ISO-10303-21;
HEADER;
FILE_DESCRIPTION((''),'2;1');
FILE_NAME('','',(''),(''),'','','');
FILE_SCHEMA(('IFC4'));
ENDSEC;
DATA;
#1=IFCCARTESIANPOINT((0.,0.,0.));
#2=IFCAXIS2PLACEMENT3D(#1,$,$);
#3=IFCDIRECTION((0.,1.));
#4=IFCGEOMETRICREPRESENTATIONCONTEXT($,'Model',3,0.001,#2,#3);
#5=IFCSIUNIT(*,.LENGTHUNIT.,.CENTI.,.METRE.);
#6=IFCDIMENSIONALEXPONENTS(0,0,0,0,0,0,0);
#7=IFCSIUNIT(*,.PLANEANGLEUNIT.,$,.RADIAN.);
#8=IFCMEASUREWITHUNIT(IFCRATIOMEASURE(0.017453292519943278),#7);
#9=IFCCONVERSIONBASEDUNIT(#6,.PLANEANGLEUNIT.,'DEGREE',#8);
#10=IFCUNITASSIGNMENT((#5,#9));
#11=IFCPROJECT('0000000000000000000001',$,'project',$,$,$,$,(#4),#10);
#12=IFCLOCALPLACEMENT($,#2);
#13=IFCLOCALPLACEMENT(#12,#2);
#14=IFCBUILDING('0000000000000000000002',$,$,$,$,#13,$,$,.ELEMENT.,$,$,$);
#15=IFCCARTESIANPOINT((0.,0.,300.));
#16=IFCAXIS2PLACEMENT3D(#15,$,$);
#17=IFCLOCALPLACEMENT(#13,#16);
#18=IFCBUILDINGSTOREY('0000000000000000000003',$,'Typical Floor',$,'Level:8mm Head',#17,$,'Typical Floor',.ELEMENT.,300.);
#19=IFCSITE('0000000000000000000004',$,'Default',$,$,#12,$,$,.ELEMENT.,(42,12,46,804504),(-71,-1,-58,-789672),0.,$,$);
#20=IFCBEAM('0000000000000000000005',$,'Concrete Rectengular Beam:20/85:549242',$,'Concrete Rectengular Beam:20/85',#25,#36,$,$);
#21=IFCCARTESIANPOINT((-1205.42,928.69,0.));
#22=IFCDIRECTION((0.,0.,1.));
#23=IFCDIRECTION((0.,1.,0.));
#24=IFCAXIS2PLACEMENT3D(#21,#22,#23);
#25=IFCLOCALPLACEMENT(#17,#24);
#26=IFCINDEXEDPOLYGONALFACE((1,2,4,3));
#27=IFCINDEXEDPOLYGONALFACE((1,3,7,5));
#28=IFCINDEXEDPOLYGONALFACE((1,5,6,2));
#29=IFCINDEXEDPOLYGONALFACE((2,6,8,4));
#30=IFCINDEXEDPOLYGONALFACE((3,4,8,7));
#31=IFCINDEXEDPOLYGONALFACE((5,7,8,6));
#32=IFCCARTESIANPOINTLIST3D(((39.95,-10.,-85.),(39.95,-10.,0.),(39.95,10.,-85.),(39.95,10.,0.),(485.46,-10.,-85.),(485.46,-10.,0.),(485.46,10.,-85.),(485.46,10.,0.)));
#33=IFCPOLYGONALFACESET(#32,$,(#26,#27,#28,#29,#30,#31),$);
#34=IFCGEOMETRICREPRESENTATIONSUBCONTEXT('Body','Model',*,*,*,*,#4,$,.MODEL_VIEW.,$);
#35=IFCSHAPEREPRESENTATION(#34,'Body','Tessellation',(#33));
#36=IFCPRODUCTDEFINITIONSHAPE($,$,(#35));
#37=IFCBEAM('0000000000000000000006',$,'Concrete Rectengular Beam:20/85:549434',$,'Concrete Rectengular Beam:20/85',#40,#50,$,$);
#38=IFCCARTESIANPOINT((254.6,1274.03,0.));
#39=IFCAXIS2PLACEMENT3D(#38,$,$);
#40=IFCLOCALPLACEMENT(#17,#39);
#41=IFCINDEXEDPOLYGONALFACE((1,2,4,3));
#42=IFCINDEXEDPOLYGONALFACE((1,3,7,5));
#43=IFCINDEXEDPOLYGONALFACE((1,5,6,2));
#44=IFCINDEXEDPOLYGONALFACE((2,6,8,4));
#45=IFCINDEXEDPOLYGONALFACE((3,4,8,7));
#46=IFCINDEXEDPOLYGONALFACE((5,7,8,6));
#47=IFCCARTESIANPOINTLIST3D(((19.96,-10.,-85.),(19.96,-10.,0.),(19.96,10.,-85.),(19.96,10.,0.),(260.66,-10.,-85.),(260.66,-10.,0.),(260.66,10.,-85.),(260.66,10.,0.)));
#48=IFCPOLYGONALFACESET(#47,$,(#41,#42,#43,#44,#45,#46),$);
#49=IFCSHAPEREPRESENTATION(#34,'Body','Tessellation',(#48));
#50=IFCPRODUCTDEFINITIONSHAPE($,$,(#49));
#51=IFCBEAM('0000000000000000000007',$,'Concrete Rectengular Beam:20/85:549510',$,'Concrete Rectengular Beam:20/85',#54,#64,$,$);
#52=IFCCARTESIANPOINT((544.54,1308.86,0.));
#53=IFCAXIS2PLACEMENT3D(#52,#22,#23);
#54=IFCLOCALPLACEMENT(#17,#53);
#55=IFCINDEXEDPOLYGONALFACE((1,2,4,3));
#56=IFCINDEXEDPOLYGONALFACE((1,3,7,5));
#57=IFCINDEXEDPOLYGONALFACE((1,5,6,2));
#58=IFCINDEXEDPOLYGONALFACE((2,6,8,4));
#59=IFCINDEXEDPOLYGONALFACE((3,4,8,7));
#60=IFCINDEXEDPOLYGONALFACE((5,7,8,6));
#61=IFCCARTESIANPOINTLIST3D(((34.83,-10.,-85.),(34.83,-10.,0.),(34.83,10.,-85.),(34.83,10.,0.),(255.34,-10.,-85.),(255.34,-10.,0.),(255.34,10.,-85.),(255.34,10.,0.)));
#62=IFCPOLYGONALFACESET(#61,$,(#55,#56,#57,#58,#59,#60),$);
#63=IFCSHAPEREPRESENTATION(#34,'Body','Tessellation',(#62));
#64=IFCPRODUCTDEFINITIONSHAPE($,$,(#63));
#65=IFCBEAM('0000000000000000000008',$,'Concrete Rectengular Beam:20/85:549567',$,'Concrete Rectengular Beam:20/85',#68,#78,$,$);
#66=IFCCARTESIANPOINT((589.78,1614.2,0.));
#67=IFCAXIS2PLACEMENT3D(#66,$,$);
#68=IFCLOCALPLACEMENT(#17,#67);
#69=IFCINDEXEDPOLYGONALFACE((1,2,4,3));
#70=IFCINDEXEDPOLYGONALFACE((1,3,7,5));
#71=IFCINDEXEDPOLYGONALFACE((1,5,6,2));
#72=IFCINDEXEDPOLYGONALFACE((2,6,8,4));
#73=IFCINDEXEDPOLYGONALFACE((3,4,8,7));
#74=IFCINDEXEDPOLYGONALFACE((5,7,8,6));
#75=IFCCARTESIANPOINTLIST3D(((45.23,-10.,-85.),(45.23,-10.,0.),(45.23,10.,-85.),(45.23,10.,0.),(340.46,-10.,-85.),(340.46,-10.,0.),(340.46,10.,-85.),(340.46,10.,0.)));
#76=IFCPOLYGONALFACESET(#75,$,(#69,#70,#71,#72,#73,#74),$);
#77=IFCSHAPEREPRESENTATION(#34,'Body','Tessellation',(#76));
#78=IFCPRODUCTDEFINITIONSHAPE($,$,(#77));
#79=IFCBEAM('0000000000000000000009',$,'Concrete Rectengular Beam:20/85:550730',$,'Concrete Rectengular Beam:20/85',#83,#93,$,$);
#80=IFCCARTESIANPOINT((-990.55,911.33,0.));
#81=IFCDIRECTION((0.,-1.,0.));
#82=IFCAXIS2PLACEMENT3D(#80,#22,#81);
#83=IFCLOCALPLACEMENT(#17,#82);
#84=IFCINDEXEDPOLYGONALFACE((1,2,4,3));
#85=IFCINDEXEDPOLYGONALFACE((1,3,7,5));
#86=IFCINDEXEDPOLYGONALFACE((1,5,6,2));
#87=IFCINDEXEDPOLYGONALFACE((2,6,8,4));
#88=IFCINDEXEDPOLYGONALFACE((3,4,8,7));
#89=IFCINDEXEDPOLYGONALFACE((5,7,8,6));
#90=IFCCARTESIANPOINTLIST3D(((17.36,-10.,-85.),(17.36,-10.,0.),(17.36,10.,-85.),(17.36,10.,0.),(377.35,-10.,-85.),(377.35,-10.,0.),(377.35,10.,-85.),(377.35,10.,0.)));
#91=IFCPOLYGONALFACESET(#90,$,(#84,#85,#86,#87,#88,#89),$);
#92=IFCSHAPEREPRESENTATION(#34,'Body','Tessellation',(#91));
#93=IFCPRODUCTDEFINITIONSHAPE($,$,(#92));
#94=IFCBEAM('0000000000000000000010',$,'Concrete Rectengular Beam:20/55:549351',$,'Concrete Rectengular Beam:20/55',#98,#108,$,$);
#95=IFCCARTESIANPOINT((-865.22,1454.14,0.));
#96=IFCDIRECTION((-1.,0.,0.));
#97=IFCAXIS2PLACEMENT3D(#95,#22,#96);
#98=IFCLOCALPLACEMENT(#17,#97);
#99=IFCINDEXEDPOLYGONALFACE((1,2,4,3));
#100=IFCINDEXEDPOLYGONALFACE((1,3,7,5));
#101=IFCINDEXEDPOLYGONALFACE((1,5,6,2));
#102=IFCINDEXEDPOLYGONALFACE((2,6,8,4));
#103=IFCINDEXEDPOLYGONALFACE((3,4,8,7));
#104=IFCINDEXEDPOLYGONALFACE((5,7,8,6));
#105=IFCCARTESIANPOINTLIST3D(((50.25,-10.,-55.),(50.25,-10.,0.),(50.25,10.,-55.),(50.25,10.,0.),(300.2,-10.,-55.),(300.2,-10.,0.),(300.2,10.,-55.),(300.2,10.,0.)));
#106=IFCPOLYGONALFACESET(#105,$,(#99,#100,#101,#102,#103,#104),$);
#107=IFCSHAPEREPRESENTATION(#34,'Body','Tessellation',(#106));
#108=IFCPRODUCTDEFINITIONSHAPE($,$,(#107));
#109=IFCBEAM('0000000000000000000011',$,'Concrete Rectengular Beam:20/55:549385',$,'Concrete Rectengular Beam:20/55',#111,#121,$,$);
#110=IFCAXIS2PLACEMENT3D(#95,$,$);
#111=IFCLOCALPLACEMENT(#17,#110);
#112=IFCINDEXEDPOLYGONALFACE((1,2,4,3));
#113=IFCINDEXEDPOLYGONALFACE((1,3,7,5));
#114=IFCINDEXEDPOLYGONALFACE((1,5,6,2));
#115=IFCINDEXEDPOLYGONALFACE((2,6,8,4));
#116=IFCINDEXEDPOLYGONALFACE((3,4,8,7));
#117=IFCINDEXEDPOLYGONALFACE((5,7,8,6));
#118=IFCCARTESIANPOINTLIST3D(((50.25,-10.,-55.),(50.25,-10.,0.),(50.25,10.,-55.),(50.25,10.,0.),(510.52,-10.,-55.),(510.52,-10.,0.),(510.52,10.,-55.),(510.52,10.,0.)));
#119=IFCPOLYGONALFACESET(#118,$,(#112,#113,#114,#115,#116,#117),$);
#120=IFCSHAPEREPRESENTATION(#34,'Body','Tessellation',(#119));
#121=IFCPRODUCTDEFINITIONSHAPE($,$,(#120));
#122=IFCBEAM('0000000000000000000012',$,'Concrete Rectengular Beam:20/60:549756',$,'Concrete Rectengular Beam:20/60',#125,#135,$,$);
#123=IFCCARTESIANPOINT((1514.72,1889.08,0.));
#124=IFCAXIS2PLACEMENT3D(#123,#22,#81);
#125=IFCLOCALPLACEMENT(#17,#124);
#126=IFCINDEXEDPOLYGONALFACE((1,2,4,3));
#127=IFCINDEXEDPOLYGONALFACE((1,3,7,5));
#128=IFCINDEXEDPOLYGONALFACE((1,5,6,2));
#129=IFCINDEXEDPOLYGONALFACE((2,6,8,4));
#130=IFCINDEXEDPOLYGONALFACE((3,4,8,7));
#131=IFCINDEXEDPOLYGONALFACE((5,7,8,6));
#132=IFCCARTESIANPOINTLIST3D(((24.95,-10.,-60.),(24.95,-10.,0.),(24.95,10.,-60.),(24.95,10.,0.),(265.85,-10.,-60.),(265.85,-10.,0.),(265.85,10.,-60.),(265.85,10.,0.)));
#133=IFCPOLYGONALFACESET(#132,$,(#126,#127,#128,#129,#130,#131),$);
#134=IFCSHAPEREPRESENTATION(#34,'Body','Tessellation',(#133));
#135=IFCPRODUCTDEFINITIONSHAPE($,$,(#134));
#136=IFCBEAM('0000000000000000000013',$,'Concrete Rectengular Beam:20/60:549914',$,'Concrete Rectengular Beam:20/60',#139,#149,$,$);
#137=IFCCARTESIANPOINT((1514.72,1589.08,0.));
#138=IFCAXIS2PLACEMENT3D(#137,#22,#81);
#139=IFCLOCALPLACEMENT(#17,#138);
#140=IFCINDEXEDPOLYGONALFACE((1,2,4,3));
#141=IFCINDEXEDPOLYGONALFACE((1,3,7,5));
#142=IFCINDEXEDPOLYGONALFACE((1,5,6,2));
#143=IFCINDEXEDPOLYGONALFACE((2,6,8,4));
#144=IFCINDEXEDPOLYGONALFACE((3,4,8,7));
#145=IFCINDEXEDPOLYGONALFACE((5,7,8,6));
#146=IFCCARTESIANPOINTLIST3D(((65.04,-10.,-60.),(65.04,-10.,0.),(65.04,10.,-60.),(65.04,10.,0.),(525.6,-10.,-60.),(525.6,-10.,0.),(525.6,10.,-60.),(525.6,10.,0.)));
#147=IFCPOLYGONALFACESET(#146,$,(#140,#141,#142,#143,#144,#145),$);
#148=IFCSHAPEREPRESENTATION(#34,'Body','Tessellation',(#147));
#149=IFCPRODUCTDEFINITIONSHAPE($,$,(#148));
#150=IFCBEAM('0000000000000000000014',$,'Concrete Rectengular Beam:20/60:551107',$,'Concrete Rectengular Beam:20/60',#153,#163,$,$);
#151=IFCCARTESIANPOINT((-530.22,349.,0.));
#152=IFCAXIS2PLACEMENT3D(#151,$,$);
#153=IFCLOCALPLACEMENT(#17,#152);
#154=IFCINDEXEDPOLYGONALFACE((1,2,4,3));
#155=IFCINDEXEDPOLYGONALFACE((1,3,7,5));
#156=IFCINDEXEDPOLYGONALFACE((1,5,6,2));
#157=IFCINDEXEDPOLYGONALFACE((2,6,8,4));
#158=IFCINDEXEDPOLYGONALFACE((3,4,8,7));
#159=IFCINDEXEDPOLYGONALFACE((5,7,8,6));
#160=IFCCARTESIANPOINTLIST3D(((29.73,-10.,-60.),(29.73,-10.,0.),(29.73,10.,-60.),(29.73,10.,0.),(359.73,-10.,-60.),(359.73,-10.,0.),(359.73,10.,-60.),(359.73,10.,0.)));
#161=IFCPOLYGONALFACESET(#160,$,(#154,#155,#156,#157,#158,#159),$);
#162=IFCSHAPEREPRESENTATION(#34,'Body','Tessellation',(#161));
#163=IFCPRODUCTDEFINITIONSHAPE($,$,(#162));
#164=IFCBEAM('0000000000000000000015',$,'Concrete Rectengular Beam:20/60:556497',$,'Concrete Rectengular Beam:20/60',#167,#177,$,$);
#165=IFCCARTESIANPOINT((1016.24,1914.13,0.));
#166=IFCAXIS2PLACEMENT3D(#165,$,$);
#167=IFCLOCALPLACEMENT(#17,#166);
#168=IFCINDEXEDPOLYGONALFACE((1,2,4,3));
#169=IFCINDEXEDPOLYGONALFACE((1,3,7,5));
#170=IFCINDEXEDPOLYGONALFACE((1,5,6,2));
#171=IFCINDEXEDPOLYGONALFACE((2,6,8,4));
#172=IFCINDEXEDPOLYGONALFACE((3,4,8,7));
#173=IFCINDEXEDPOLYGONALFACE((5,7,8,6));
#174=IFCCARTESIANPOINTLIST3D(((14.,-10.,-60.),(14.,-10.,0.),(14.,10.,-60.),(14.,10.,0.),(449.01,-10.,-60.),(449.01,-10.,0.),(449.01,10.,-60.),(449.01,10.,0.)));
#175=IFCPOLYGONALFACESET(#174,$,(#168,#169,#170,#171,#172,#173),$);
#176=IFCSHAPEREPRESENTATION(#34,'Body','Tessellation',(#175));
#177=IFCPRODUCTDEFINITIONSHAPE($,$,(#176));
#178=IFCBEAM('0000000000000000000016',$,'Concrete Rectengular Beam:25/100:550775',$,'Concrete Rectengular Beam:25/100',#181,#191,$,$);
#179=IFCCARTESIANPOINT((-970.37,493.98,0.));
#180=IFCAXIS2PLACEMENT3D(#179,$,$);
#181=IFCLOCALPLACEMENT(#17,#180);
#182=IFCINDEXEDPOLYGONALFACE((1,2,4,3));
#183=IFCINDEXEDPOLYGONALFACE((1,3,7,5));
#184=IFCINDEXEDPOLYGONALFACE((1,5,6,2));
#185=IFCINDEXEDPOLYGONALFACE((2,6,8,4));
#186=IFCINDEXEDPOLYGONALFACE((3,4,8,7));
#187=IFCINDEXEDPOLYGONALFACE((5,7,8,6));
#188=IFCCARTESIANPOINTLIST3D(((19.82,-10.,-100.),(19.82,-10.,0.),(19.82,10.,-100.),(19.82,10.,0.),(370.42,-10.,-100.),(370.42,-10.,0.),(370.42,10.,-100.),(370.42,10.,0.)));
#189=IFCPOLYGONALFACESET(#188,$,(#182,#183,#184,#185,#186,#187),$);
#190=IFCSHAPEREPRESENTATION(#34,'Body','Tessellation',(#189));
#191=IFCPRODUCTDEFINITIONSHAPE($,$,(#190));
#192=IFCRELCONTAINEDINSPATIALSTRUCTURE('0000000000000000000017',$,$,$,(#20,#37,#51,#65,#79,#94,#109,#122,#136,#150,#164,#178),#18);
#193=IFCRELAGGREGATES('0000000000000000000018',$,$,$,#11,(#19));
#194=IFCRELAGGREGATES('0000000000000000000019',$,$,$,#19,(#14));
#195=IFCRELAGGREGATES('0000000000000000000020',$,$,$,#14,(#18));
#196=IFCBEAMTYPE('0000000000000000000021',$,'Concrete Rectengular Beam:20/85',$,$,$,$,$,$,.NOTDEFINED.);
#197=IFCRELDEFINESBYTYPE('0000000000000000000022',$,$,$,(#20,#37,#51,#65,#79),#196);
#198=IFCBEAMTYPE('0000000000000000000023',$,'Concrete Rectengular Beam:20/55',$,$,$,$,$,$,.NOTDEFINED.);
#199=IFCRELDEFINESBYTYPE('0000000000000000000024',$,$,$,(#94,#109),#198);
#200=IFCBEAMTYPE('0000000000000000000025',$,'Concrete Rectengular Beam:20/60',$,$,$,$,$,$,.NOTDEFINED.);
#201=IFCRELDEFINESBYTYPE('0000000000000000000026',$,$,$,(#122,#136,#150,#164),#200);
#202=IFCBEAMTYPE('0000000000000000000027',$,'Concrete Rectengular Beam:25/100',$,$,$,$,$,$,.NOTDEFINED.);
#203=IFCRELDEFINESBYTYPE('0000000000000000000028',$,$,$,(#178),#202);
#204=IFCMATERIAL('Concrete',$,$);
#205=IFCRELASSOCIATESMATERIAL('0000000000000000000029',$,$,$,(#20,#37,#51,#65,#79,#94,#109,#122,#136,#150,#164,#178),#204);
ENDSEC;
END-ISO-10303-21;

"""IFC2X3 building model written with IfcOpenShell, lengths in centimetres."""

from ifc_helpers import new_model, entity, si_unit, converted_unit, direction, frame, frame_2d, origin, place, context, subcontext, project, spatial, rectangle, extrude, material, type_object, element, save


model = new_model("IFC2X3")

# Units and contexts
model_context = context("Model", 3, precision=0.001, world=origin(), true_north=direction((0.0, 1.0)))
body_context = subcontext(model_context, "Body", "Model", "MODEL_VIEW")
ifc_project = project(units=[si_unit("LENGTHUNIT", "METRE", prefix="CENTI"), converted_unit("PLANEANGLEUNIT", "DEGREE", entity("IfcRatioMeasure", 0.017453292519943278), si_unit("PLANEANGLEUNIT", "RADIAN"), dimensions=[0, 0, 0, 0, 0, 0, 0])], contexts=[model_context])

# Site, building, storey
site_placement = place(None, origin())
site = spatial("IfcSite", under=ifc_project, at=site_placement, Name="Default", CompositionType="ELEMENT", RefLatitude=(42, 12, 46, 804504), RefLongitude=(-71, -1, -58, -789672), RefElevation=0.0)
building_placement = place(site_placement, origin())
building = spatial("IfcBuilding", under=site, at=building_placement, CompositionType="ELEMENT")
storey_placement = place(building_placement, frame((0.0, 0.0, 300.0)))
storey = spatial("IfcBuildingStorey", under=building, at=storey_placement, Name="Typical Floor", ObjectType="Level:8mm Head", LongName="Typical Floor", CompositionType="ELEMENT", Elevation=300.0)

# Beams
ifc_material = material(Name="Concrete")
beam_type_1 = type_object("IfcBeamType", Name="Concrete Rectengular Beam:20/85", PredefinedType="NOTDEFINED")
beam_1_placement = place(storey_placement, frame((-1205.42, 928.69, 0.0), z_axis=(0.0, 0.0, 1.0), x_axis=(0.0, 1.0, 0.0)))
element("IfcBeam", 1, at=beam_1_placement, inside=storey, type_object=beam_type_1, material=ifc_material, Name="Concrete Rectengular Beam:20/85:549242", ObjectType="Concrete Rectengular Beam:20/85", context=body_context, shape_type="SweptSolid", body=[
    extrude(rectangle(XDim=85.0, YDim=20.0, at=frame_2d((0.0, 0.0), x_axis=(1.0, 0.0))), frame((39.95, 0.0, -42.5), z_axis=(1.0, 0.0, 0.0), x_axis=(0.0, 0.0, -1.0)), (0.0, 0.0, 1.0), 445.5),
])
beam_2_placement = place(storey_placement, frame((254.6, 1274.03, 0.0)))
element("IfcBeam", 2, at=beam_2_placement, inside=storey, type_object=beam_type_1, material=ifc_material, Name="Concrete Rectengular Beam:20/85:549434", ObjectType="Concrete Rectengular Beam:20/85", context=body_context, shape_type="SweptSolid", body=[
    extrude(rectangle(XDim=85.0, YDim=20.0, at=frame_2d((0.0, 0.0), x_axis=(1.0, 0.0))), frame((19.96, 0.0, -42.5), z_axis=(1.0, 0.0, 0.0), x_axis=(0.0, 0.0, -1.0)), (0.0, 0.0, 1.0), 240.7),
])
beam_3_placement = place(storey_placement, frame((544.54, 1308.86, 0.0), z_axis=(0.0, 0.0, 1.0), x_axis=(0.0, 1.0, 0.0)))
element("IfcBeam", 3, at=beam_3_placement, inside=storey, type_object=beam_type_1, material=ifc_material, Name="Concrete Rectengular Beam:20/85:549510", ObjectType="Concrete Rectengular Beam:20/85", context=body_context, shape_type="SweptSolid", body=[
    extrude(rectangle(XDim=85.0, YDim=20.0, at=frame_2d((0.0, 0.0), x_axis=(1.0, 0.0))), frame((34.83, 0.0, -42.5), z_axis=(1.0, 0.0, 0.0), x_axis=(0.0, 0.0, -1.0)), (0.0, 0.0, 1.0), 220.51),
])
beam_4_placement = place(storey_placement, frame((589.78, 1614.2, 0.0)))
element("IfcBeam", 4, at=beam_4_placement, inside=storey, type_object=beam_type_1, material=ifc_material, Name="Concrete Rectengular Beam:20/85:549567", ObjectType="Concrete Rectengular Beam:20/85", context=body_context, shape_type="SweptSolid", body=[
    extrude(rectangle(XDim=85.0, YDim=20.0, at=frame_2d((0.0, 0.0), x_axis=(1.0, 0.0))), frame((45.23, 0.0, -42.5), z_axis=(1.0, 0.0, 0.0), x_axis=(0.0, 0.0, -1.0)), (0.0, 0.0, 1.0), 295.23),
])
beam_5_placement = place(storey_placement, frame((-990.55, 911.33, 0.0), z_axis=(0.0, 0.0, 1.0), x_axis=(0.0, -1.0, 0.0)))
element("IfcBeam", 5, at=beam_5_placement, inside=storey, type_object=beam_type_1, material=ifc_material, Name="Concrete Rectengular Beam:20/85:550730", ObjectType="Concrete Rectengular Beam:20/85", context=body_context, shape_type="SweptSolid", body=[
    extrude(rectangle(XDim=85.0, YDim=20.0, at=frame_2d((0.0, 0.0), x_axis=(1.0, 0.0))), frame((17.36, 0.0, -42.5), z_axis=(1.0, 0.0, 0.0), x_axis=(0.0, 0.0, -1.0)), (0.0, 0.0, 1.0), 359.99),
])
beam_type_2 = type_object("IfcBeamType", Name="Concrete Rectengular Beam:20/55", PredefinedType="NOTDEFINED")
beam_6_placement = place(storey_placement, frame((-865.22, 1454.14, 0.0), z_axis=(0.0, 0.0, 1.0), x_axis=(-1.0, 0.0, 0.0)))
element("IfcBeam", 6, at=beam_6_placement, inside=storey, type_object=beam_type_2, material=ifc_material, Name="Concrete Rectengular Beam:20/55:549351", ObjectType="Concrete Rectengular Beam:20/55", context=body_context, shape_type="SweptSolid", body=[
    extrude(rectangle(XDim=55.0, YDim=20.0, at=frame_2d((0.0, 0.0), x_axis=(1.0, 0.0))), frame((50.25, 0.0, -27.5), z_axis=(1.0, 0.0, 0.0), x_axis=(0.0, 0.0, -1.0)), (0.0, 0.0, 1.0), 249.95),
])
beam_7_placement = place(storey_placement, frame((-865.22, 1454.14, 0.0)))
element("IfcBeam", 7, at=beam_7_placement, inside=storey, type_object=beam_type_2, material=ifc_material, Name="Concrete Rectengular Beam:20/55:549385", ObjectType="Concrete Rectengular Beam:20/55", context=body_context, shape_type="SweptSolid", body=[
    extrude(rectangle(XDim=55.0, YDim=20.0, at=frame_2d((0.0, 0.0), x_axis=(1.0, 0.0))), frame((50.25, 0.0, -27.5), z_axis=(1.0, 0.0, 0.0), x_axis=(0.0, 0.0, -1.0)), (0.0, 0.0, 1.0), 460.27),
])
beam_type_3 = type_object("IfcBeamType", Name="Concrete Rectengular Beam:20/60", PredefinedType="NOTDEFINED")
beam_8_placement = place(storey_placement, frame((1514.72, 1889.08, 0.0), z_axis=(0.0, 0.0, 1.0), x_axis=(0.0, -1.0, 0.0)))
element("IfcBeam", 8, at=beam_8_placement, inside=storey, type_object=beam_type_3, material=ifc_material, Name="Concrete Rectengular Beam:20/60:549756", ObjectType="Concrete Rectengular Beam:20/60", context=body_context, shape_type="SweptSolid", body=[
    extrude(rectangle(XDim=60.0, YDim=20.0, at=frame_2d((0.0, 0.0), x_axis=(1.0, 0.0))), frame((24.95, 0.0, -30.0), z_axis=(1.0, 0.0, 0.0), x_axis=(0.0, 0.0, -1.0)), (0.0, 0.0, 1.0), 240.9),
])
beam_9_placement = place(storey_placement, frame((1514.72, 1589.08, 0.0), z_axis=(0.0, 0.0, 1.0), x_axis=(0.0, -1.0, 0.0)))
element("IfcBeam", 9, at=beam_9_placement, inside=storey, type_object=beam_type_3, material=ifc_material, Name="Concrete Rectengular Beam:20/60:549914", ObjectType="Concrete Rectengular Beam:20/60", context=body_context, shape_type="SweptSolid", body=[
    extrude(rectangle(XDim=60.0, YDim=20.0, at=frame_2d((0.0, 0.0), x_axis=(1.0, 0.0))), frame((65.04, 0.0, -30.0), z_axis=(1.0, 0.0, 0.0), x_axis=(0.0, 0.0, -1.0)), (0.0, 0.0, 1.0), 460.56),
])
beam_10_placement = place(storey_placement, frame((-530.22, 349.0, 0.0)))
element("IfcBeam", 10, at=beam_10_placement, inside=storey, type_object=beam_type_3, material=ifc_material, Name="Concrete Rectengular Beam:20/60:551107", ObjectType="Concrete Rectengular Beam:20/60", context=body_context, shape_type="SweptSolid", body=[
    extrude(rectangle(XDim=60.0, YDim=20.0, at=frame_2d((0.0, 0.0), x_axis=(1.0, 0.0))), frame((29.73, 0.0, -30.0), z_axis=(1.0, 0.0, 0.0), x_axis=(0.0, 0.0, -1.0)), (0.0, 0.0, 1.0), 330.01),
])
beam_11_placement = place(storey_placement, frame((1016.24, 1914.13, 0.0)))
element("IfcBeam", 11, at=beam_11_placement, inside=storey, type_object=beam_type_3, material=ifc_material, Name="Concrete Rectengular Beam:20/60:556497", ObjectType="Concrete Rectengular Beam:20/60", context=body_context, shape_type="SweptSolid", body=[
    extrude(rectangle(XDim=60.0, YDim=20.0, at=frame_2d((0.0, 0.0), x_axis=(1.0, 0.0))), frame((14.0, 0.0, -30.0), z_axis=(1.0, 0.0, 0.0), x_axis=(0.0, 0.0, -1.0)), (0.0, 0.0, 1.0), 435.01),
])
beam_type_4 = type_object("IfcBeamType", Name="Concrete Rectengular Beam:25/100", PredefinedType="NOTDEFINED")
beam_12_placement = place(storey_placement, frame((-970.37, 493.98, 0.0)))
element("IfcBeam", 12, at=beam_12_placement, inside=storey, type_object=beam_type_4, material=ifc_material, Name="Concrete Rectengular Beam:25/100:550775", ObjectType="Concrete Rectengular Beam:25/100", context=body_context, shape_type="SweptSolid", body=[
    extrude(rectangle(XDim=100.0, YDim=20.0, at=frame_2d((0.0, 0.0), x_axis=(1.0, 0.0))), frame((19.82, 0.0, -50.0), z_axis=(1.0, 0.0, 0.0), x_axis=(0.0, 0.0, -1.0)), (0.0, 0.0, 1.0), 350.61),
])

save(model, "model.ifc")
